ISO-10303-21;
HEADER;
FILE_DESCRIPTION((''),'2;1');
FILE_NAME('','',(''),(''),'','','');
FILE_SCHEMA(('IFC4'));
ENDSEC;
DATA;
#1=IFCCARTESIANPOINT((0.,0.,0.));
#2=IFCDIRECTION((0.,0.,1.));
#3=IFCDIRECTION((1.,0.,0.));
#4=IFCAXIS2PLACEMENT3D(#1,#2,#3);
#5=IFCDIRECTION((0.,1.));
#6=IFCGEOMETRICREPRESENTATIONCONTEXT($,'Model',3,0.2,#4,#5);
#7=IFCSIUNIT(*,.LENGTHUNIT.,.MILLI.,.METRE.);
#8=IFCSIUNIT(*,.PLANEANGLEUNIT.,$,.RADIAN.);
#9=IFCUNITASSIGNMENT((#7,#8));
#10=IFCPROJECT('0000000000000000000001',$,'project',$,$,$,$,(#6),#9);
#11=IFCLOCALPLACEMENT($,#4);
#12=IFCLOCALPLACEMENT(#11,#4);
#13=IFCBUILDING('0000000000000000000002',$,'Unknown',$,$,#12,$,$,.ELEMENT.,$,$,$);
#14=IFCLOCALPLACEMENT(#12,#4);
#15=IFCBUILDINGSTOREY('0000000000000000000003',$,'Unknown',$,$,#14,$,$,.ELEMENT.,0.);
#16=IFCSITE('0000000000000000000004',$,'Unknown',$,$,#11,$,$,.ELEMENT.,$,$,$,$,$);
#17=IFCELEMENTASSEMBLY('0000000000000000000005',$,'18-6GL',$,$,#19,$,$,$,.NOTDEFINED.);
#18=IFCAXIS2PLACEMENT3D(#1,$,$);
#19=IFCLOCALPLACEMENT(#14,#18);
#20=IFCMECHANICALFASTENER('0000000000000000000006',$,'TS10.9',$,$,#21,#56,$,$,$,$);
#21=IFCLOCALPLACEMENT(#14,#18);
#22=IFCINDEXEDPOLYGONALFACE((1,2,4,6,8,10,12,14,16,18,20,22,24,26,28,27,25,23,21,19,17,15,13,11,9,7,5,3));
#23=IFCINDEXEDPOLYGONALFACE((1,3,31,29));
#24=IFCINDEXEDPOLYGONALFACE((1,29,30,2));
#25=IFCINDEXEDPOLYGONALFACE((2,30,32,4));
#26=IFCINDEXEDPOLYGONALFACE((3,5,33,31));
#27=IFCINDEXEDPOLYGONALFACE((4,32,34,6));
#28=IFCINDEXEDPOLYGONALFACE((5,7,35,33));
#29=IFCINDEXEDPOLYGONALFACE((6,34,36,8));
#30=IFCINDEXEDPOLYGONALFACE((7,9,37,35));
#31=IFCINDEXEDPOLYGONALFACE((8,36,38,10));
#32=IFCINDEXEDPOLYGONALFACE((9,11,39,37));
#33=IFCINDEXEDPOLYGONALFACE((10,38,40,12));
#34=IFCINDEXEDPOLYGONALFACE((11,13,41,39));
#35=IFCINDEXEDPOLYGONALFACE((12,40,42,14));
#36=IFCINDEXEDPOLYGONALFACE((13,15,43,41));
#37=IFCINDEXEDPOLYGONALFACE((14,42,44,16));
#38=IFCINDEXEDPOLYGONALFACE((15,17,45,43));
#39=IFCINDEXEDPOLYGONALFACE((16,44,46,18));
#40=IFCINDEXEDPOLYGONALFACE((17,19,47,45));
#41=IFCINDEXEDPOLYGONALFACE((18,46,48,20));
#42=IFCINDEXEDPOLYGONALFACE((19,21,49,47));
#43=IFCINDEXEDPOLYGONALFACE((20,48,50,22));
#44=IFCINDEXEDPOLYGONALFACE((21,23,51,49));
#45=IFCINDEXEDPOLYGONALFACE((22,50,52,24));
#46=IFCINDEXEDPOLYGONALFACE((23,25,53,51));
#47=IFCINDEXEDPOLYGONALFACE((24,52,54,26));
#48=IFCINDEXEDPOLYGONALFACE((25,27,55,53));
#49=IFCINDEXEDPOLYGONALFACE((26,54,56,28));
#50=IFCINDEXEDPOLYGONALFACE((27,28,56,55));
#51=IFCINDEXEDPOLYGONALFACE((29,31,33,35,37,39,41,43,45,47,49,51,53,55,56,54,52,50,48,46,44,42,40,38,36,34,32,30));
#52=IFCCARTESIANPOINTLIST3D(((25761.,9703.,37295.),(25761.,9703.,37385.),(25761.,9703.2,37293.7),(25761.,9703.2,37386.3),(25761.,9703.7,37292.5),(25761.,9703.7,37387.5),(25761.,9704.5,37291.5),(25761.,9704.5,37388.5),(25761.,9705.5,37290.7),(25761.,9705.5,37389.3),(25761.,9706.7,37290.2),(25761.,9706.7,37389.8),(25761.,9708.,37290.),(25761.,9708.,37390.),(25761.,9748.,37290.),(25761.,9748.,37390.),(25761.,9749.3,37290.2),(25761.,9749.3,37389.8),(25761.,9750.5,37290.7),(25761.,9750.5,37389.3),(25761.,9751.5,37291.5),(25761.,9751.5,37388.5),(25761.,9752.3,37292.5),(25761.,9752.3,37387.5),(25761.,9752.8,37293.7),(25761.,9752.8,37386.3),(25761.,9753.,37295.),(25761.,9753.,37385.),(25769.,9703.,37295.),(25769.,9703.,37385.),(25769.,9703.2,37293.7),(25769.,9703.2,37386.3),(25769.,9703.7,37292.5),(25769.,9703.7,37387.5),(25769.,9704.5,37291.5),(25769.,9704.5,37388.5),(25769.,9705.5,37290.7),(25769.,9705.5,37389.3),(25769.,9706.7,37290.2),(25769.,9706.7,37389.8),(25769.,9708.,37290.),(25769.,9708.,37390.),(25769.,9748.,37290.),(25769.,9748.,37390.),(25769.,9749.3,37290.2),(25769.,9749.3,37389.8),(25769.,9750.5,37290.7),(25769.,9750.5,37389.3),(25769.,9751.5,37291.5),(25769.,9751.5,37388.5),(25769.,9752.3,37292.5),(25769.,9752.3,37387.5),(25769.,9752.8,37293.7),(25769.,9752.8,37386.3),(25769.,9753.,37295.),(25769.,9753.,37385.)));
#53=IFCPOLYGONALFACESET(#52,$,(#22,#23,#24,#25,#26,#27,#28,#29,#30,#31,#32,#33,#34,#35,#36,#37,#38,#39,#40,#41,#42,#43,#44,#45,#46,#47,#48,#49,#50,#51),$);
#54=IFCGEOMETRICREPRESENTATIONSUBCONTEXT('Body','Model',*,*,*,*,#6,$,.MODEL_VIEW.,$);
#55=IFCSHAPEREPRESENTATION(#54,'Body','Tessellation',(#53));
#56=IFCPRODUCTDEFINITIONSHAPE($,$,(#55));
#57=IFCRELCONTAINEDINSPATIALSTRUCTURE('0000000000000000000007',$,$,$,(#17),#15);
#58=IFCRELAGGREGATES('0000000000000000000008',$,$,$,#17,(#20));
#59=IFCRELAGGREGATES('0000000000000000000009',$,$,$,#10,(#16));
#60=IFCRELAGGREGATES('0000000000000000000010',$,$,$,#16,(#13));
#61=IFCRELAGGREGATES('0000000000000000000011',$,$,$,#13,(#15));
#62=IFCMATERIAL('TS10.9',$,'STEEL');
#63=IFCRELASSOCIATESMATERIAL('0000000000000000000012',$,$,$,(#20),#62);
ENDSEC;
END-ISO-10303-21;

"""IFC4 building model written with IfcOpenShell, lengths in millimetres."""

from ifc_helpers import new_model, si_unit, direction, frame, origin_with_axes, place, context, subcontext, project, spatial, line, arc, indexed_curve, outline, extrude, source, transform, mapped, material, element, aggregate, save


model = new_model("IFC4")

# Units and contexts
model_context = context("Model", 3, precision=0.2, world=origin_with_axes(), true_north=direction((0.0, 1.0)))
body_context = subcontext(model_context, "Body", "Model", "MODEL_VIEW")
ifc_project = project(units=[si_unit("LENGTHUNIT", "METRE", prefix="MILLI"), si_unit("PLANEANGLEUNIT", "RADIAN")], contexts=[model_context])

# Site, building, storey
site_placement = place(None, origin_with_axes())
site = spatial("IfcSite", under=ifc_project, at=site_placement, Name="Unknown", CompositionType="ELEMENT")
building_placement = place(site_placement, origin_with_axes())
building = spatial("IfcBuilding", under=site, at=building_placement, Name="Unknown", CompositionType="ELEMENT")
storey_placement = place(building_placement, origin_with_axes())
storey = spatial("IfcBuildingStorey", under=building, at=storey_placement, Name="Unknown", CompositionType="ELEMENT", Elevation=0.0)

# Element assembly
assembly_1_placement = place(storey_placement, frame((25765.0, 10900.0, 37340.0), z_axis=(-1.0, 0.0, 0.0), x_axis=(0.0, -1.0, 0.0)))
assembly_1 = element("IfcElementAssembly", 1, at=assembly_1_placement, inside=storey, Name="18-6GL", PredefinedType="NOTDEFINED")

# Mechanical fastener
ifc_material_1 = material(Name="TS10.9", Category="STEEL")
shared_shape_1 = source(origin_with_axes(), body_context, "Body", "SweptSolid", [
    extrude(outline(indexed_curve([(-45.0, 25.0), (45.0, 25.0), (45.0, 25.0), (48.5, 23.5), (50.0, 20.0), (50.0, -20.0), (48.5, -23.5), (45.0, -25.0), (-45.0, -25.0), (-45.5, -25.0), (-50.0, -20.0), (-50.0, 20.0), (-48.5, 23.5)], segments=[line(1, 2, 3), arc(3, 4, 5), line(5, 6), arc(6, 7, 8), line(8, 9), arc(9, 10, 11), line(11, 12), arc(12, 13, 1)])), frame((0.0, 0.0, 4.0), z_axis=(0.0, 0.0, -1.0), x_axis=(0.0, 1.0, 0.0)), (0.0, 0.0, 1.0), 8.0),
])
mechanical_fastener_1_placement = place(assembly_1_placement, frame((1172.0, 0.0, 0.0), z_axis=(0.0, 0.0, 1.0), x_axis=(-1.0, 0.0, 0.0)))
mechanical_fastener_1 = element("IfcMechanicalFastener", 2, at=mechanical_fastener_1_placement, material=ifc_material_1, Name="TS10.9", context=body_context, shape_type="MappedRepresentation", body=[
    mapped(shared_shape_1, transform((0.0, 0.0, 0.0))),
])
aggregate(assembly_1, [mechanical_fastener_1])

save(model, "model.ifc")
